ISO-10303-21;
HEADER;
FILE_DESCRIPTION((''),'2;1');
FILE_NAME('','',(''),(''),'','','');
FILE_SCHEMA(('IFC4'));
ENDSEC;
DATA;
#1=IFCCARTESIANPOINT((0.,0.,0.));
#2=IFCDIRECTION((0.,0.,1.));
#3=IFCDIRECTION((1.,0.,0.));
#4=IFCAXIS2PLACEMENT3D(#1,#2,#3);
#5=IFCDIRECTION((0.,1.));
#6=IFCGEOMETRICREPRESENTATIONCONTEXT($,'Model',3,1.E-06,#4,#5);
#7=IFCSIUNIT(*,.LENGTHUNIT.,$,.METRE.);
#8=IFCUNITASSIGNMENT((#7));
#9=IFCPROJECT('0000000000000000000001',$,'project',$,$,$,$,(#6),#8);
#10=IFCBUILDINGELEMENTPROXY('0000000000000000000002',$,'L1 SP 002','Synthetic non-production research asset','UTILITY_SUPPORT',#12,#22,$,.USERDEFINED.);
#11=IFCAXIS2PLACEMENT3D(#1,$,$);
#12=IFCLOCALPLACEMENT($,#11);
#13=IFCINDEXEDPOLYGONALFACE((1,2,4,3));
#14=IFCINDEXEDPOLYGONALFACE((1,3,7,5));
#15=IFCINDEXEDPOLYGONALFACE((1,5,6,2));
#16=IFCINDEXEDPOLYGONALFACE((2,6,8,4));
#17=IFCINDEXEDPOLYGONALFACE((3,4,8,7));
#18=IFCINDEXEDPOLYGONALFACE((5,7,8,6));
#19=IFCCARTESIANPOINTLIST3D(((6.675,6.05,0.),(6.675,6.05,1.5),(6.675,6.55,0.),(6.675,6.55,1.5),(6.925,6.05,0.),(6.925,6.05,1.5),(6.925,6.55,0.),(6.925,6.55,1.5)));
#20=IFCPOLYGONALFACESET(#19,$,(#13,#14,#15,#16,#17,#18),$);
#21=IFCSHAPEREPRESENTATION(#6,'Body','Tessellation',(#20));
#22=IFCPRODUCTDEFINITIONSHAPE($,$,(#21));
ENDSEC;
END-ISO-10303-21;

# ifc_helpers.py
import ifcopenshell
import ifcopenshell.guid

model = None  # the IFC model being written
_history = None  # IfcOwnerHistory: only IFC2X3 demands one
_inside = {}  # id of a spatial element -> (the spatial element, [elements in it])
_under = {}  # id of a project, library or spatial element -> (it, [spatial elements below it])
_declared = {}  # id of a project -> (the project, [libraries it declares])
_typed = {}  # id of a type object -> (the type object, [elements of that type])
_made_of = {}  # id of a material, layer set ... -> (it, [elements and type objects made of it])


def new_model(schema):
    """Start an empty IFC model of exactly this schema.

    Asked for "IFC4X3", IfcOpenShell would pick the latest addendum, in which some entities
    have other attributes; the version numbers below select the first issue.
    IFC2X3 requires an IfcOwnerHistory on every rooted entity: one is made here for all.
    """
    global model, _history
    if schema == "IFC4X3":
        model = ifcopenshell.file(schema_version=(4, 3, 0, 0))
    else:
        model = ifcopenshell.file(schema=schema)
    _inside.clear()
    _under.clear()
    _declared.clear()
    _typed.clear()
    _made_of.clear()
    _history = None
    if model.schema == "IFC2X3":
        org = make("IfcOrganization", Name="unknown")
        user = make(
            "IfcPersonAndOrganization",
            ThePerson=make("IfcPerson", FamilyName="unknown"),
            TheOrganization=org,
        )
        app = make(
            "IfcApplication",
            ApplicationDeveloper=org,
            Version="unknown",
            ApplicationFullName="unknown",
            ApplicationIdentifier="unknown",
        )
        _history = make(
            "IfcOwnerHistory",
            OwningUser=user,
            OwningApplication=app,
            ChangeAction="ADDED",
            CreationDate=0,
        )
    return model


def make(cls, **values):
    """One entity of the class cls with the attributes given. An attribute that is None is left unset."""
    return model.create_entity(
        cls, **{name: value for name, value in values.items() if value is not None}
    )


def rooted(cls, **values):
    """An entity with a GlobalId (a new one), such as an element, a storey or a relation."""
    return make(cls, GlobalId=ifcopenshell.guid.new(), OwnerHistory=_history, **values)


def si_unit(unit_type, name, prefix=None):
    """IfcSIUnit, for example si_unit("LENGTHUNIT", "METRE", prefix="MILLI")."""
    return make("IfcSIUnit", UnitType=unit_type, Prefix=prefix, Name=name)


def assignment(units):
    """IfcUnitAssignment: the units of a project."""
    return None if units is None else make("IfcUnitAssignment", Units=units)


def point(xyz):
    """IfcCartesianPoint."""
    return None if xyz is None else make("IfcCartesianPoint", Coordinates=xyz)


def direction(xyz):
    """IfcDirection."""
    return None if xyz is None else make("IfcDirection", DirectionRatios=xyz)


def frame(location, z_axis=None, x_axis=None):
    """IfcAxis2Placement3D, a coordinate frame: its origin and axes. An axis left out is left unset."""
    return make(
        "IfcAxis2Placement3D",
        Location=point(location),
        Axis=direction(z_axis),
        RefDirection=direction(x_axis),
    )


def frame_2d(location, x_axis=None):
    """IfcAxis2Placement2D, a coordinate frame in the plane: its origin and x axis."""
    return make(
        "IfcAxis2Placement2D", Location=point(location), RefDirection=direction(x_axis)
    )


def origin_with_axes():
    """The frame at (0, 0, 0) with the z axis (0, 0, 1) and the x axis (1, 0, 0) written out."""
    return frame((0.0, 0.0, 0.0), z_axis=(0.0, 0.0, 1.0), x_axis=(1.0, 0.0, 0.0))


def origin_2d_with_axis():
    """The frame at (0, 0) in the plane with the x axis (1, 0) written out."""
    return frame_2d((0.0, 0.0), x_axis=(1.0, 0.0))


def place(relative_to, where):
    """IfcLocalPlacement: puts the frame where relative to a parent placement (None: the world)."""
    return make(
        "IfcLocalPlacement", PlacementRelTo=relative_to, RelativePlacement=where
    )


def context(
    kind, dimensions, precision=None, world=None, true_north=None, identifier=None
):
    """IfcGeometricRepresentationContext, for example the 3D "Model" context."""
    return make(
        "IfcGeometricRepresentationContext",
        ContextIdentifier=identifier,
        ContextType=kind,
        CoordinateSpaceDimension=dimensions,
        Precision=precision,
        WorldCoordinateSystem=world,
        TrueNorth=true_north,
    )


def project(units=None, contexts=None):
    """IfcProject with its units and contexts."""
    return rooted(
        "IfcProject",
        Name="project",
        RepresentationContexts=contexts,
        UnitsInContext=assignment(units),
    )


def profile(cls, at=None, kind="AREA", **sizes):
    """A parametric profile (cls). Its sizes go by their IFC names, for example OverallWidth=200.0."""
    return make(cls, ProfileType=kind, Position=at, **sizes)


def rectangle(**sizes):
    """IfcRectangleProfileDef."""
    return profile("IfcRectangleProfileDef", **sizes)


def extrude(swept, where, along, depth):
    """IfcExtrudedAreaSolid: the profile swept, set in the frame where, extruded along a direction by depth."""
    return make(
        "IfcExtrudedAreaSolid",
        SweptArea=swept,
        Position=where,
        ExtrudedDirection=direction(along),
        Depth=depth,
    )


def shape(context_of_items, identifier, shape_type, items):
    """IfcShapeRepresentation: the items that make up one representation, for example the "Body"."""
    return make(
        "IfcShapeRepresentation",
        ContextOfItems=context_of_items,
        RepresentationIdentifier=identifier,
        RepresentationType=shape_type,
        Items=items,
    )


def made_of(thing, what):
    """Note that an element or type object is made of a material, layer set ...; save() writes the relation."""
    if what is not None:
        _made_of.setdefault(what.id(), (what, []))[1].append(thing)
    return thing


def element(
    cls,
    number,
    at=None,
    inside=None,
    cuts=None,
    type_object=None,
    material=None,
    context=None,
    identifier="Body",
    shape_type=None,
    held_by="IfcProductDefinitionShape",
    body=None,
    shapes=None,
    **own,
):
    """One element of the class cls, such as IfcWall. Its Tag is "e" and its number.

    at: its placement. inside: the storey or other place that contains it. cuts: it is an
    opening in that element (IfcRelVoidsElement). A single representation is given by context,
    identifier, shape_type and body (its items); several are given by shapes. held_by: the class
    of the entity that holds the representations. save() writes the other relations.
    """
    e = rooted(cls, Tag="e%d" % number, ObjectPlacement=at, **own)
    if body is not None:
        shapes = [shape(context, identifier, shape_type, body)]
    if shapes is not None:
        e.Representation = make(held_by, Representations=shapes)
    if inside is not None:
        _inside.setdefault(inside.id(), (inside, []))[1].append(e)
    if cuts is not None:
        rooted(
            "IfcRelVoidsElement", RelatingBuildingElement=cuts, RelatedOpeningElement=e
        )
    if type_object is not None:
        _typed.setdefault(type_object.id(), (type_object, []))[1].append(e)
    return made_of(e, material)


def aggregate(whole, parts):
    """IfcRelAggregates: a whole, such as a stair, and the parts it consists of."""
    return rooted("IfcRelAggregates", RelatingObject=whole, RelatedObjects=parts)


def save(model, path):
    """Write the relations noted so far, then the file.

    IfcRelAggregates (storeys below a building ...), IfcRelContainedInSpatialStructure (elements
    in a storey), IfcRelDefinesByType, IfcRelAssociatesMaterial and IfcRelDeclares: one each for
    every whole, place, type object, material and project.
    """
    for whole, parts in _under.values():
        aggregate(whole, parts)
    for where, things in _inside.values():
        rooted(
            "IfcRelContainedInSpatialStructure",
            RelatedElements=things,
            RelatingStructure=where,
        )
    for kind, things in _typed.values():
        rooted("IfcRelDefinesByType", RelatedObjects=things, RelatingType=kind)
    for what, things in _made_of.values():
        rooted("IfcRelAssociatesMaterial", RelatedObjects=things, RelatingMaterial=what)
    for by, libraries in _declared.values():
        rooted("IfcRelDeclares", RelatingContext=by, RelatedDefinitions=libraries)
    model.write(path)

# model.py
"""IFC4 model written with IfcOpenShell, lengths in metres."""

from ifc_helpers import new_model, si_unit, direction, frame, origin_with_axes, origin_2d_with_axis, place, context, project, rectangle, extrude, element, save


model = new_model("IFC4")

# Units and contexts
model_context = context("Model", 3, precision=1e-06, world=origin_with_axes(), true_north=direction((0.0, 1.0)))
ifc_project = project(units=[si_unit("LENGTHUNIT", "METRE")], contexts=[model_context])

# Building element proxy
proxy_placement = place(None, frame((6.8, 6.3, 0.0), z_axis=(0.0, 0.0, 1.0), x_axis=(1.0, 0.0, 0.0)))
element("IfcBuildingElementProxy", 1, at=proxy_placement, Name="L1 SP 002", Description="Synthetic non-production research asset", ObjectType="UTILITY_SUPPORT", PredefinedType="USERDEFINED", context=model_context, shape_type="SweptSolid", body=[
    extrude(rectangle(XDim=0.25, YDim=0.5, at=origin_2d_with_axis()), origin_with_axes(), (0.0, 0.0, 1.0), 1.5),
])

save(model, "model.ifc")
